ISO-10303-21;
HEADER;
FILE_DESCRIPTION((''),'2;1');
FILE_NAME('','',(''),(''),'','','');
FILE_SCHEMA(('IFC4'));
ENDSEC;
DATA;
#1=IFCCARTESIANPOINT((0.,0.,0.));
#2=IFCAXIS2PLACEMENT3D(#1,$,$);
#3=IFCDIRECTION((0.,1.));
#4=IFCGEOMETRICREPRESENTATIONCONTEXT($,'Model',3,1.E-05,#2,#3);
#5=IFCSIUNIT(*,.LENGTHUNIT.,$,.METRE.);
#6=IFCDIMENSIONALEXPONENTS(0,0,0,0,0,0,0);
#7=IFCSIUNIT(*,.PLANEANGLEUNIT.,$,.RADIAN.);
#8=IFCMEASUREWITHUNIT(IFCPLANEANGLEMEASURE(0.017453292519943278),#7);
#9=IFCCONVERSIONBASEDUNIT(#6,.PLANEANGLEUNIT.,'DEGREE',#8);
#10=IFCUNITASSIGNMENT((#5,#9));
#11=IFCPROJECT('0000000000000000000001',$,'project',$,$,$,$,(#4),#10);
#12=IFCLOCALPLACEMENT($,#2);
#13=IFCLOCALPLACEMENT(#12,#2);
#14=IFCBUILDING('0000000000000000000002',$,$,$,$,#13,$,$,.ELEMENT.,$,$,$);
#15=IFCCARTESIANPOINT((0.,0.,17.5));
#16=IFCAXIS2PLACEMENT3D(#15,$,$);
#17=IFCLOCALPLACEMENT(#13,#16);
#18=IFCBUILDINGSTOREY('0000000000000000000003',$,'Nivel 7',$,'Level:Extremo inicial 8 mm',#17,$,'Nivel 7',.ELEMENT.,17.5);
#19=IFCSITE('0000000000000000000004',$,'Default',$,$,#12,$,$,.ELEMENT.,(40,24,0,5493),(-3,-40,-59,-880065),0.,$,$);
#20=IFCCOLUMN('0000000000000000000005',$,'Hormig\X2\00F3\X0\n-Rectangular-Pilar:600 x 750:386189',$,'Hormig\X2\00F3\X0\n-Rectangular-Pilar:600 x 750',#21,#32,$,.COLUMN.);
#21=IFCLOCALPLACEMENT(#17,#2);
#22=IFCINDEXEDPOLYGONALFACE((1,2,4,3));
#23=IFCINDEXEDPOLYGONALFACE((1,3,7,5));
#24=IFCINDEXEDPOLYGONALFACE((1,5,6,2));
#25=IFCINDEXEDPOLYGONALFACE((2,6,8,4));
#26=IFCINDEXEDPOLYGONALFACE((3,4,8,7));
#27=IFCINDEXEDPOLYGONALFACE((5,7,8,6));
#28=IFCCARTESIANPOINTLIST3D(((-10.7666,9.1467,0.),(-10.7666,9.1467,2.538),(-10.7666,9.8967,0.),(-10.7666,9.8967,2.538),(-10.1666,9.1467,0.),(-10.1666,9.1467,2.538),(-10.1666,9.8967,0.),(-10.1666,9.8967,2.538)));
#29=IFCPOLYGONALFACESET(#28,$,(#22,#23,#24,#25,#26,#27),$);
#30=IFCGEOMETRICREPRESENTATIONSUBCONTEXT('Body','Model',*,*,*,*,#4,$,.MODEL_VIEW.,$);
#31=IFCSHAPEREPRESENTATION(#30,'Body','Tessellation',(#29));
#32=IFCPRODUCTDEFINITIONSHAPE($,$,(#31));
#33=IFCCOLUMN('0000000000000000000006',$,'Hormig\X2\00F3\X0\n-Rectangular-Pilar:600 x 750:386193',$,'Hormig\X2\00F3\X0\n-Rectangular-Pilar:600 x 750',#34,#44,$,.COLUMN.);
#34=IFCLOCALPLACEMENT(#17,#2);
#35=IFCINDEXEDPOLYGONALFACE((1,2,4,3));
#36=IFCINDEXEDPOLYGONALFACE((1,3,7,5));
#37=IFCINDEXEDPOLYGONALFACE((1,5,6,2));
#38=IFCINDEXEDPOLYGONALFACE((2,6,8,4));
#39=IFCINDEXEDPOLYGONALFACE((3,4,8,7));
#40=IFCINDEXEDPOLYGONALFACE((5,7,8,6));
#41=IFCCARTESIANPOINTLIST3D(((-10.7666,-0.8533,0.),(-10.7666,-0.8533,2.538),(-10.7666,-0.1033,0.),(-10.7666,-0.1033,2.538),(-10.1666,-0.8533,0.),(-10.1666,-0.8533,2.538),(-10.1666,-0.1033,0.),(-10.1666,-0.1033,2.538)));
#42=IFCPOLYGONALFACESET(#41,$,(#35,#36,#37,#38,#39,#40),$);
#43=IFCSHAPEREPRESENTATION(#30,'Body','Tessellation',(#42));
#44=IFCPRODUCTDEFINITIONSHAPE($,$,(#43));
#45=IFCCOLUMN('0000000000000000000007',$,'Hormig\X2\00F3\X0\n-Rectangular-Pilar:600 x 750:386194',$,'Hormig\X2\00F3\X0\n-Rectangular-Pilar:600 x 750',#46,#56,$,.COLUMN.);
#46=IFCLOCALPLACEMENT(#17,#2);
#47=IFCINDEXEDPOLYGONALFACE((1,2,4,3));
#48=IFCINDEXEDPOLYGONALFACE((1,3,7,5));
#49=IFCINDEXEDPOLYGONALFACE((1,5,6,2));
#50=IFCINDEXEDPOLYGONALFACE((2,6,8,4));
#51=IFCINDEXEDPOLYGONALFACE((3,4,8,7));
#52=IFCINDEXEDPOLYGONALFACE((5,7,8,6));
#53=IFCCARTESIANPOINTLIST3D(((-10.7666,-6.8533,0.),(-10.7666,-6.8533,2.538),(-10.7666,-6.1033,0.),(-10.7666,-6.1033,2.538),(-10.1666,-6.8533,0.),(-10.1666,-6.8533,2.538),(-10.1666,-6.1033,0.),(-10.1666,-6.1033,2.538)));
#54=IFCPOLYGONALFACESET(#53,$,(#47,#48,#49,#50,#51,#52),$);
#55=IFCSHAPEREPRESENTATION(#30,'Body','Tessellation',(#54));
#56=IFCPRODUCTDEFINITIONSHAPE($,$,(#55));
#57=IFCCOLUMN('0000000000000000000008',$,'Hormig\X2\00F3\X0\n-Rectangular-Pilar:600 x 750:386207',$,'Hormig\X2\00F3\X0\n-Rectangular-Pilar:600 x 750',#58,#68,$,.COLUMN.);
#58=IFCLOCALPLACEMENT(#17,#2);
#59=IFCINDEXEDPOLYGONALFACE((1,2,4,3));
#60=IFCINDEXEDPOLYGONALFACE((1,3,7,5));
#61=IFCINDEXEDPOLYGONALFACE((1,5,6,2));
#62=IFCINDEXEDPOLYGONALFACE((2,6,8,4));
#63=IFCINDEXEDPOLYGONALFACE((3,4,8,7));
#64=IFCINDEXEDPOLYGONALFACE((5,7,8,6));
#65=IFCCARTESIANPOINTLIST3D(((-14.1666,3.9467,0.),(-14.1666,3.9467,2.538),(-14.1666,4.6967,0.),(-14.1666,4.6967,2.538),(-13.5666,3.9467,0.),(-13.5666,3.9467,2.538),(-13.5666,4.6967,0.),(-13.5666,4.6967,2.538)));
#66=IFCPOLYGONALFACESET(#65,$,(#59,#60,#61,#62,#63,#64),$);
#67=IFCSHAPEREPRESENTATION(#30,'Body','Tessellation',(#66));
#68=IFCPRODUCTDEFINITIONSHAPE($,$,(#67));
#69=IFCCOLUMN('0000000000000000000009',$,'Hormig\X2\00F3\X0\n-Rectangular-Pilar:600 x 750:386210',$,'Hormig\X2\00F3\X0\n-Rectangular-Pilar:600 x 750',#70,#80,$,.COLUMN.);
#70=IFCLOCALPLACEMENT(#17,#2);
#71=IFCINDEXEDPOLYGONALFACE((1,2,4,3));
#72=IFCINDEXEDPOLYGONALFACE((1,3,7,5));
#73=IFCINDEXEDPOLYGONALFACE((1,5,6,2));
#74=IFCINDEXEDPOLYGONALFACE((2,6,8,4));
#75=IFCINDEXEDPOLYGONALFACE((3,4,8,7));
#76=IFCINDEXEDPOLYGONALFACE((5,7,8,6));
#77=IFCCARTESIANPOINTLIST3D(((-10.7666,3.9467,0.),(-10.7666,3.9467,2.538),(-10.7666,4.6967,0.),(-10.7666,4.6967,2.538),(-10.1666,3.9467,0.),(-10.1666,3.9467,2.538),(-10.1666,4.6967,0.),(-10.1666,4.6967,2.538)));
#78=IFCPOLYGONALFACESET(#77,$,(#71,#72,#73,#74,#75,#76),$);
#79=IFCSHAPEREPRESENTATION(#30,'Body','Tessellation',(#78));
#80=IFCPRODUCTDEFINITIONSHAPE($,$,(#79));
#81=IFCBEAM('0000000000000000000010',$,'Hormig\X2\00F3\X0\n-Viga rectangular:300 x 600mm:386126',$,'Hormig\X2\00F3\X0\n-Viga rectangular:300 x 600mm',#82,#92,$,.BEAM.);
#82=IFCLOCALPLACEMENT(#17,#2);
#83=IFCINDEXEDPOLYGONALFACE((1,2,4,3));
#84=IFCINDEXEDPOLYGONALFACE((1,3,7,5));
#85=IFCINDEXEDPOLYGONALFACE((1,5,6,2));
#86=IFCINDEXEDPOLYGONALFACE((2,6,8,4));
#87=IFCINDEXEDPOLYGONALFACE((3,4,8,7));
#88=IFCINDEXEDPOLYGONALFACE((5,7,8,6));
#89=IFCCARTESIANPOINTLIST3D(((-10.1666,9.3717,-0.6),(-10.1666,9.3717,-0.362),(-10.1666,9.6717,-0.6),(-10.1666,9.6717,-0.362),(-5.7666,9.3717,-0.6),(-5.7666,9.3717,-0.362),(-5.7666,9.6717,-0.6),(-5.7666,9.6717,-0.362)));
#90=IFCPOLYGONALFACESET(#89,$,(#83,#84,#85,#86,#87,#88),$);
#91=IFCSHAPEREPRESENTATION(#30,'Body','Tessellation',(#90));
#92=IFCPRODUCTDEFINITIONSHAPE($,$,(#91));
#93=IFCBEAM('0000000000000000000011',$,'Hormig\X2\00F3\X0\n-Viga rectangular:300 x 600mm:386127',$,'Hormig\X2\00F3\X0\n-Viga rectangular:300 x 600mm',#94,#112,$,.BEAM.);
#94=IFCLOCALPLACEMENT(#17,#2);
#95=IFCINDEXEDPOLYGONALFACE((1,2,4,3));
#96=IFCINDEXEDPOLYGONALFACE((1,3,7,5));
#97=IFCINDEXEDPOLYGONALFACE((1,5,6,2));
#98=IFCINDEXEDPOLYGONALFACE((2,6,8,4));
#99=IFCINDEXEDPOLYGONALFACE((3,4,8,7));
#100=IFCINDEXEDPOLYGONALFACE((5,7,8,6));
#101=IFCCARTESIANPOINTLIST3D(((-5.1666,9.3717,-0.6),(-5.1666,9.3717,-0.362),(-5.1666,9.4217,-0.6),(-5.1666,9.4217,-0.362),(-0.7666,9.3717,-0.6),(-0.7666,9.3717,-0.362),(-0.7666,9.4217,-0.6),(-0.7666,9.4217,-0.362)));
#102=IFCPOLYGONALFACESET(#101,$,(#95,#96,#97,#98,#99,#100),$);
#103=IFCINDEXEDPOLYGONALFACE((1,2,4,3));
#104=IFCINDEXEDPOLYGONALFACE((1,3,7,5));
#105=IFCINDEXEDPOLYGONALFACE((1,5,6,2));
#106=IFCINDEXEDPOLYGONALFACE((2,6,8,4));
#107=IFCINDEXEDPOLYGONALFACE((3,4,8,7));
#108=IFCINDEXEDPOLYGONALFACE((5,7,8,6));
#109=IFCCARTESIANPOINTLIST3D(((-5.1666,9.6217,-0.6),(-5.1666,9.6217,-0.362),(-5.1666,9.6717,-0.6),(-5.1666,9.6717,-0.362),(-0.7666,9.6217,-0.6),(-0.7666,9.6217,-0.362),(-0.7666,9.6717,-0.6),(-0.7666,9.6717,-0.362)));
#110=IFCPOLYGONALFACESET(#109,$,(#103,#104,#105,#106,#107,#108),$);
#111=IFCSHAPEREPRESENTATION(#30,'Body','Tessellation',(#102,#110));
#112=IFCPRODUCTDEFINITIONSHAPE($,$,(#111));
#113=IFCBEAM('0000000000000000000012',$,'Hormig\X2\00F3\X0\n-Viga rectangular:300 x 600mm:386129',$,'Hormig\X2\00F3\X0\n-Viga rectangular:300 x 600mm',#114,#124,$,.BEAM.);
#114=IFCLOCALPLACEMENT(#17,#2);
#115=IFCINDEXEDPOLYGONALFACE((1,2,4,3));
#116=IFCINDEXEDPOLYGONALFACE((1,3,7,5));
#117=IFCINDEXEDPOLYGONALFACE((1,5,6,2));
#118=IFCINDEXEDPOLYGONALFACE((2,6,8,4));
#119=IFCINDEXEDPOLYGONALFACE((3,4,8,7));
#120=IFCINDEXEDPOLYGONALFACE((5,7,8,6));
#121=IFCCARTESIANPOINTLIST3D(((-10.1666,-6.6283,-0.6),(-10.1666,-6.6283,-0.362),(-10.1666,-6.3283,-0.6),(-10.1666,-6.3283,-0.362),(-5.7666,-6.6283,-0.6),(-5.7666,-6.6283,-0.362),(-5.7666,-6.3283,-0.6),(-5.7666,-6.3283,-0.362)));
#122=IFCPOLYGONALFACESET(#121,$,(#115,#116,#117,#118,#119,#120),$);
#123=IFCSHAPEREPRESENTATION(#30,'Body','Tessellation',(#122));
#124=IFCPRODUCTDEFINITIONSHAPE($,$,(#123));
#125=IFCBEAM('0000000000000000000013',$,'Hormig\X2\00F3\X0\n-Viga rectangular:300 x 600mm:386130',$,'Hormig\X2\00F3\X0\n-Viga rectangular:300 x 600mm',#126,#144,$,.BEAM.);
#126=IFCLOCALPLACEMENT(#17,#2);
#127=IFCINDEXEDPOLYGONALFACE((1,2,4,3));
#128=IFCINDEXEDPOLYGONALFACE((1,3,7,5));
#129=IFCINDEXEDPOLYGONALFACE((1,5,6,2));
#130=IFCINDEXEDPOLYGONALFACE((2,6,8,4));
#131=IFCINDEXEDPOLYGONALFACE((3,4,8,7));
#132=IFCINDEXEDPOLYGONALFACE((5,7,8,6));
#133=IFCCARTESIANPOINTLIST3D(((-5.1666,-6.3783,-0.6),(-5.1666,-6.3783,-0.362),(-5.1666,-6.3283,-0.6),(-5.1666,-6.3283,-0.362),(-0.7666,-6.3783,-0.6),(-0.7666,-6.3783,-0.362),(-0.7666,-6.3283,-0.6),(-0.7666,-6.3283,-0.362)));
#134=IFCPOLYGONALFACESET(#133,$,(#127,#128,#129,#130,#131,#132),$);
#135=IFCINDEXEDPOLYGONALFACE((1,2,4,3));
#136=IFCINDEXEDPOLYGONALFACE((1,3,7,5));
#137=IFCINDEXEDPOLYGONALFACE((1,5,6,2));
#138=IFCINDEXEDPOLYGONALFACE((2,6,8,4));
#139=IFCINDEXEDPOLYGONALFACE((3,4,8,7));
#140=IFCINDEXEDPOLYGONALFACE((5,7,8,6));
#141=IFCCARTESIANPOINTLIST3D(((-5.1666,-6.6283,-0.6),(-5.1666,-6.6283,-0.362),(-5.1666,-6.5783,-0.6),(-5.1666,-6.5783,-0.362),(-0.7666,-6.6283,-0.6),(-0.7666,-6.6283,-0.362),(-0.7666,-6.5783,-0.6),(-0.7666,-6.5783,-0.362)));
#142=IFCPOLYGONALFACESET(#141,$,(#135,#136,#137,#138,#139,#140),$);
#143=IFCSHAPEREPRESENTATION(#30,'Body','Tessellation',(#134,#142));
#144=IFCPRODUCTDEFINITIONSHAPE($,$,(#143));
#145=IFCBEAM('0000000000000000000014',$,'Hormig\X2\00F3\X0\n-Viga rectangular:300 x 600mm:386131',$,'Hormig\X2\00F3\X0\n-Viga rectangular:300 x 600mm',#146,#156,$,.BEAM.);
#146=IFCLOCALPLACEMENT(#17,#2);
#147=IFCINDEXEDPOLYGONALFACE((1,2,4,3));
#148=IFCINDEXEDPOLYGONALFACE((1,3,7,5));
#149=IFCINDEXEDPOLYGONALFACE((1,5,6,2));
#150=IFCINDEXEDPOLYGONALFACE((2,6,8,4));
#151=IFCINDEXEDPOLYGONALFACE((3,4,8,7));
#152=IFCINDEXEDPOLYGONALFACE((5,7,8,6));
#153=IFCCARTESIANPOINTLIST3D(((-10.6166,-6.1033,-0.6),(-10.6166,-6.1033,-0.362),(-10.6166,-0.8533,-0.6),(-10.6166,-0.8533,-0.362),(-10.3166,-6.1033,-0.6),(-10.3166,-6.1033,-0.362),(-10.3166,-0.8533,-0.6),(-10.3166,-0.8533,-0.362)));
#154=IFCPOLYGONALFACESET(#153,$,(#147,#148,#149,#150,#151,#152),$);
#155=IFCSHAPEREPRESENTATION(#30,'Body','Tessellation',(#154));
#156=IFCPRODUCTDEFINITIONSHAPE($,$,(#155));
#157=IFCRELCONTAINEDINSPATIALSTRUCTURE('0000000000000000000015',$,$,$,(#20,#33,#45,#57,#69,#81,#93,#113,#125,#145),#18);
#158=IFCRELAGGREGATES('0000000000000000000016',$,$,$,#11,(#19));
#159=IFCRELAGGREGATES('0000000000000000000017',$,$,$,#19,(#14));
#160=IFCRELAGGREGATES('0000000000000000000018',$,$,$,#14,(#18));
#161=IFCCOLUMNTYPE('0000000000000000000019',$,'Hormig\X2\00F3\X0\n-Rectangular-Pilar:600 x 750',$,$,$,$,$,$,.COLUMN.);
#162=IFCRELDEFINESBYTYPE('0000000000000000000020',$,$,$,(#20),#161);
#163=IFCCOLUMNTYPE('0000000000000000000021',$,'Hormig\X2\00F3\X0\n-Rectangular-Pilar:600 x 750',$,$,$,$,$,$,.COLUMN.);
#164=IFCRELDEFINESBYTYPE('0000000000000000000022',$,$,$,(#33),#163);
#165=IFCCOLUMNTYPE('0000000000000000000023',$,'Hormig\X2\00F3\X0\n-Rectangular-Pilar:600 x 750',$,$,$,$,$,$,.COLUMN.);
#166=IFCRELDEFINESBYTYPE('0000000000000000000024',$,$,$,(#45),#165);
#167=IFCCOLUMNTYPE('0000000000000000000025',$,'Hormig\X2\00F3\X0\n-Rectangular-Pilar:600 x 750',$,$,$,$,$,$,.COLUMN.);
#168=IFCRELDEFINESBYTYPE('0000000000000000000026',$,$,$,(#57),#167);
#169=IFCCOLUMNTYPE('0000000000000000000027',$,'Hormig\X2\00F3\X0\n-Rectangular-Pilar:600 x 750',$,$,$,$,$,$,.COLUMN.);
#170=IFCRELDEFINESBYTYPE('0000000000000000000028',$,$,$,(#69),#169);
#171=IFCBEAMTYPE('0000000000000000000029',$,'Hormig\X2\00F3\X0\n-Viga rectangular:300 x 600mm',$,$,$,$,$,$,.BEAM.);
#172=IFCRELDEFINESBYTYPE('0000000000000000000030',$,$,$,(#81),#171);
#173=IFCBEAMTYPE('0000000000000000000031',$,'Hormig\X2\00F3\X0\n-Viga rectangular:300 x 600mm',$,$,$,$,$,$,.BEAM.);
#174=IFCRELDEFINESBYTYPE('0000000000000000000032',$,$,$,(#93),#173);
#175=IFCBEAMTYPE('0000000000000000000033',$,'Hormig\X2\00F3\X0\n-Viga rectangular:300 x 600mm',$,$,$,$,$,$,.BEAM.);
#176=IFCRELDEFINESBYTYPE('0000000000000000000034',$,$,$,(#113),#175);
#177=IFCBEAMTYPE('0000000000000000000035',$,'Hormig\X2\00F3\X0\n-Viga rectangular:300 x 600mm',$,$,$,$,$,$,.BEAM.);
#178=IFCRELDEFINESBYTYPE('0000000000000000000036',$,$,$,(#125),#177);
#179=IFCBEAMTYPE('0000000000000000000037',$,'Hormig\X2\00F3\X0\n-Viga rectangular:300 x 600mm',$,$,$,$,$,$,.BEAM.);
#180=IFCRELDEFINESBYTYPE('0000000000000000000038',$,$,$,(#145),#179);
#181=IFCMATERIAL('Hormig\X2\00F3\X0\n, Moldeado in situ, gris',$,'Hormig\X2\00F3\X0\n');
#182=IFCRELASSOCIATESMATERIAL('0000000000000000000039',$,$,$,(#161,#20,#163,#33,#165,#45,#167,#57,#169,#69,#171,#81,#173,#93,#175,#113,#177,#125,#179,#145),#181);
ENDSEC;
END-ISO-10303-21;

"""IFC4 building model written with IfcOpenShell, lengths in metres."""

from ifc_helpers import new_model, entity, si_unit, converted_unit, direction, frame, origin, place, context, subcontext, project, spatial, indexed_curve, outline, extrude, source, transform, mapped, material, type_object, type_shapes, element, save


model = new_model("IFC4")

# Units and contexts
model_context = context("Model", 3, precision=1e-05, world=origin(), true_north=direction((0.0, 1.0)))
body_context = subcontext(model_context, "Body", "Model", "MODEL_VIEW")
ifc_project = project(units=[si_unit("LENGTHUNIT", "METRE"), converted_unit("PLANEANGLEUNIT", "DEGREE", entity("IfcPlaneAngleMeasure", 0.017453292519943278), si_unit("PLANEANGLEUNIT", "RADIAN"), dimensions=[0, 0, 0, 0, 0, 0, 0])], contexts=[model_context])

# Site, building, storey
site_placement = place(None, origin())
site = spatial("IfcSite", under=ifc_project, at=site_placement, Name="Default", CompositionType="ELEMENT", RefLatitude=(40, 24, 0, 5493), RefLongitude=(-3, -40, -59, -880065), RefElevation=0.0)
building_placement = place(site_placement, origin())
building = spatial("IfcBuilding", under=site, at=building_placement, CompositionType="ELEMENT")
storey_placement = place(building_placement, frame((0.0, 0.0, 17.5)))
storey = spatial("IfcBuildingStorey", under=building, at=storey_placement, Name="Nivel 7", ObjectType="Level:Extremo inicial 8 mm", LongName="Nivel 7", CompositionType="ELEMENT", Elevation=17.5)

# Columns
ifc_material_1 = material(Name="Hormigón, Moldeado in situ, gris", Category="Hormigón")
column_type_1 = type_object("IfcColumnType", Name="Hormigón-Rectangular-Pilar:600 x 750", PredefinedType="COLUMN", material=ifc_material_1)
shared_shape_1 = source(origin(), body_context, "Body", "SweptSolid", [
    extrude(outline(indexed_curve([(-0.3, -0.375), (0.3, -0.375), (0.3, 0.375), (-0.3, 0.375), (-0.3, -0.375)], self_intersect=False)), frame((-10.4666, 9.5217, 17.5), z_axis=(0.0, 0.0, 1.0), x_axis=(-1.0, 0.0, 0.0)), (0.0, 0.0, 1.0), 2.538),
])
type_shapes(column_type_1, [shared_shape_1])
column_1_placement = place(storey_placement, frame((0.0, 0.0, -17.5)))
element("IfcColumn", 1, at=column_1_placement, inside=storey, type_object=column_type_1, material=ifc_material_1, Name="Hormigón-Rectangular-Pilar:600 x 750:386189", ObjectType="Hormigón-Rectangular-Pilar:600 x 750", PredefinedType="COLUMN", context=body_context, shape_type="MappedRepresentation", body=[
    mapped(shared_shape_1, transform((0.0, 0.0, 0.0), scale=1.0)),
])
column_type_2 = type_object("IfcColumnType", Name="Hormigón-Rectangular-Pilar:600 x 750", PredefinedType="COLUMN", material=ifc_material_1)
shared_shape_2 = source(origin(), body_context, "Body", "SweptSolid", [
    extrude(outline(indexed_curve([(-0.3, -0.375), (0.3, -0.375), (0.3, 0.375), (-0.3, 0.375), (-0.3, -0.375)], self_intersect=False)), frame((-10.4666, -0.4783, 17.5), z_axis=(0.0, 0.0, 1.0), x_axis=(-1.0, 0.0, 0.0)), (0.0, 0.0, 1.0), 2.538),
])
type_shapes(column_type_2, [shared_shape_2])
column_2_placement = place(storey_placement, frame((0.0, 0.0, -17.5)))
element("IfcColumn", 2, at=column_2_placement, inside=storey, type_object=column_type_2, material=ifc_material_1, Name="Hormigón-Rectangular-Pilar:600 x 750:386193", ObjectType="Hormigón-Rectangular-Pilar:600 x 750", PredefinedType="COLUMN", context=body_context, shape_type="MappedRepresentation", body=[
    mapped(shared_shape_2, transform((0.0, 0.0, 0.0), scale=1.0)),
])
column_type_3 = type_object("IfcColumnType", Name="Hormigón-Rectangular-Pilar:600 x 750", PredefinedType="COLUMN", material=ifc_material_1)
shared_shape_3 = source(origin(), body_context, "Body", "SweptSolid", [
    extrude(outline(indexed_curve([(-0.3, -0.375), (0.3, -0.375), (0.3, 0.375), (-0.3, 0.375), (-0.3, -0.375)], self_intersect=False)), frame((-10.4666, -6.4783, 17.5), z_axis=(0.0, 0.0, 1.0), x_axis=(-1.0, 0.0, 0.0)), (0.0, 0.0, 1.0), 2.538),
])
type_shapes(column_type_3, [shared_shape_3])
column_3_placement = place(storey_placement, frame((0.0, 0.0, -17.5)))
element("IfcColumn", 3, at=column_3_placement, inside=storey, type_object=column_type_3, material=ifc_material_1, Name="Hormigón-Rectangular-Pilar:600 x 750:386194", ObjectType="Hormigón-Rectangular-Pilar:600 x 750", PredefinedType="COLUMN", context=body_context, shape_type="MappedRepresentation", body=[
    mapped(shared_shape_3, transform((0.0, 0.0, 0.0), scale=1.0)),
])
column_type_4 = type_object("IfcColumnType", Name="Hormigón-Rectangular-Pilar:600 x 750", PredefinedType="COLUMN", material=ifc_material_1)
shared_shape_4 = source(origin(), body_context, "Body", "SweptSolid", [
    extrude(outline(indexed_curve([(-0.3, -0.375), (0.3, -0.375), (0.3, 0.375), (-0.3, 0.375), (-0.3, -0.375)], self_intersect=False)), frame((-13.8666, 4.3217, 17.5), z_axis=(0.0, 0.0, 1.0), x_axis=(-1.0, 0.0, 0.0)), (0.0, 0.0, 1.0), 2.538),
])
type_shapes(column_type_4, [shared_shape_4])
column_4_placement = place(storey_placement, frame((0.0, 0.0, -17.5)))
element("IfcColumn", 4, at=column_4_placement, inside=storey, type_object=column_type_4, material=ifc_material_1, Name="Hormigón-Rectangular-Pilar:600 x 750:386207", ObjectType="Hormigón-Rectangular-Pilar:600 x 750", PredefinedType="COLUMN", context=body_context, shape_type="MappedRepresentation", body=[
    mapped(shared_shape_4, transform((0.0, 0.0, 0.0), scale=1.0)),
])
column_type_5 = type_object("IfcColumnType", Name="Hormigón-Rectangular-Pilar:600 x 750", PredefinedType="COLUMN", material=ifc_material_1)
shared_shape_5 = source(origin(), body_context, "Body", "SweptSolid", [
    extrude(outline(indexed_curve([(-0.3, -0.375), (0.3, -0.375), (0.3, 0.375), (-0.3, 0.375), (-0.3, -0.375)], self_intersect=False)), frame((-10.4666, 4.3217, 17.5), z_axis=(0.0, 0.0, 1.0), x_axis=(-1.0, 0.0, 0.0)), (0.0, 0.0, 1.0), 2.538),
])
type_shapes(column_type_5, [shared_shape_5])
column_5_placement = place(storey_placement, frame((0.0, 0.0, -17.5)))
element("IfcColumn", 5, at=column_5_placement, inside=storey, type_object=column_type_5, material=ifc_material_1, Name="Hormigón-Rectangular-Pilar:600 x 750:386210", ObjectType="Hormigón-Rectangular-Pilar:600 x 750", PredefinedType="COLUMN", context=body_context, shape_type="MappedRepresentation", body=[
    mapped(shared_shape_5, transform((0.0, 0.0, 0.0), scale=1.0)),
])

# Beams
beam_type_1 = type_object("IfcBeamType", Name="Hormigón-Viga rectangular:300 x 600mm", PredefinedType="BEAM", material=ifc_material_1)
shared_shape_6 = source(origin(), body_context, "Body", "SweptSolid", [
    extrude(outline(indexed_curve([(-0.119, -0.15), (0.119, -0.15), (0.119, 0.15), (-0.119, 0.15), (-0.119, -0.15)], self_intersect=False)), frame((-5.7666, 9.5217, 17.019), z_axis=(-1.0, 0.0, 0.0), x_axis=(0.0, 0.0, -1.0)), (0.0, 0.0, 1.0), 4.4),
])
type_shapes(beam_type_1, [shared_shape_6])
beam_1_placement = place(storey_placement, frame((0.0, 0.0, -17.5)))
element("IfcBeam", 6, at=beam_1_placement, inside=storey, type_object=beam_type_1, material=ifc_material_1, Name="Hormigón-Viga rectangular:300 x 600mm:386126", ObjectType="Hormigón-Viga rectangular:300 x 600mm", PredefinedType="BEAM", context=body_context, shape_type="MappedRepresentation", body=[
    mapped(shared_shape_6, transform((0.0, 0.0, 0.0), scale=1.0)),
])
beam_type_2 = type_object("IfcBeamType", Name="Hormigón-Viga rectangular:300 x 600mm", PredefinedType="BEAM", material=ifc_material_1)
shared_shape_7 = source(origin(), body_context, "Body", "SweptSolid", [
    extrude(outline(indexed_curve([(-0.119, -0.025), (0.119, -0.025), (0.119, 0.025), (-0.119, 0.025), (-0.119, -0.025)], self_intersect=False)), frame((-5.1666, 9.3967, 17.019), z_axis=(1.0, 0.0, 0.0), x_axis=(0.0, 0.0, -1.0)), (0.0, 0.0, 1.0), 4.4),
    extrude(outline(indexed_curve([(-0.119, -0.025), (0.119, -0.025), (0.119, 0.025), (-0.119, 0.025), (-0.119, -0.025)], self_intersect=False)), frame((-5.1666, 9.6467, 17.019), z_axis=(1.0, 0.0, 0.0), x_axis=(0.0, 0.0, -1.0)), (0.0, 0.0, 1.0), 4.4),
])
type_shapes(beam_type_2, [shared_shape_7])
beam_2_placement = place(storey_placement, frame((0.0, 0.0, -17.5)))
element("IfcBeam", 7, at=beam_2_placement, inside=storey, type_object=beam_type_2, material=ifc_material_1, Name="Hormigón-Viga rectangular:300 x 600mm:386127", ObjectType="Hormigón-Viga rectangular:300 x 600mm", PredefinedType="BEAM", context=body_context, shape_type="MappedRepresentation", body=[
    mapped(shared_shape_7, transform((0.0, 0.0, 0.0), scale=1.0)),
])
beam_type_3 = type_object("IfcBeamType", Name="Hormigón-Viga rectangular:300 x 600mm", PredefinedType="BEAM", material=ifc_material_1)
shared_shape_8 = source(origin(), body_context, "Body", "SweptSolid", [
    extrude(outline(indexed_curve([(-0.119, -0.15), (0.119, -0.15), (0.119, 0.15), (-0.119, 0.15), (-0.119, -0.15)], self_intersect=False)), frame((-10.1666, -6.4783, 17.019), z_axis=(1.0, 0.0, 0.0), x_axis=(0.0, 0.0, -1.0)), (0.0, 0.0, 1.0), 4.4),
])
type_shapes(beam_type_3, [shared_shape_8])
beam_3_placement = place(storey_placement, frame((0.0, 0.0, -17.5)))
element("IfcBeam", 8, at=beam_3_placement, inside=storey, type_object=beam_type_3, material=ifc_material_1, Name="Hormigón-Viga rectangular:300 x 600mm:386129", ObjectType="Hormigón-Viga rectangular:300 x 600mm", PredefinedType="BEAM", context=body_context, shape_type="MappedRepresentation", body=[
    mapped(shared_shape_8, transform((0.0, 0.0, 0.0), scale=1.0)),
])
beam_type_4 = type_object("IfcBeamType", Name="Hormigón-Viga rectangular:300 x 600mm", PredefinedType="BEAM", material=ifc_material_1)
shared_shape_9 = source(origin(), body_context, "Body", "SweptSolid", [
    extrude(outline(indexed_curve([(-0.119, -0.025), (0.119, -0.025), (0.119, 0.025), (-0.119, 0.025), (-0.119, -0.025)], self_intersect=False)), frame((-0.7666, -6.3533, 17.019), z_axis=(-1.0, 0.0, 0.0), x_axis=(0.0, 0.0, -1.0)), (0.0, 0.0, 1.0), 4.4),
    extrude(outline(indexed_curve([(-0.119, -0.025), (0.119, -0.025), (0.119, 0.025), (-0.119, 0.025), (-0.119, -0.025)], self_intersect=False)), frame((-0.7666, -6.6033, 17.019), z_axis=(-1.0, 0.0, 0.0), x_axis=(0.0, 0.0, -1.0)), (0.0, 0.0, 1.0), 4.4),
])
type_shapes(beam_type_4, [shared_shape_9])
beam_4_placement = place(storey_placement, frame((0.0, 0.0, -17.5)))
element("IfcBeam", 9, at=beam_4_placement, inside=storey, type_object=beam_type_4, material=ifc_material_1, Name="Hormigón-Viga rectangular:300 x 600mm:386130", ObjectType="Hormigón-Viga rectangular:300 x 600mm", PredefinedType="BEAM", context=body_context, shape_type="MappedRepresentation", body=[
    mapped(shared_shape_9, transform((0.0, 0.0, 0.0), scale=1.0)),
])
beam_type_5 = type_object("IfcBeamType", Name="Hormigón-Viga rectangular:300 x 600mm", PredefinedType="BEAM", material=ifc_material_1)
shared_shape_10 = source(origin(), body_context, "Body", "SweptSolid", [
    extrude(outline(indexed_curve([(-0.15, -0.119), (0.15, -0.119), (0.15, 0.119), (-0.15, 0.119), (-0.15, -0.119)], self_intersect=False)), frame((-10.4666, -6.1033, 17.019), z_axis=(0.0, 1.0, 0.0), x_axis=(-1.0, 0.0, 0.0)), (0.0, 0.0, 1.0), 5.25),
])
type_shapes(beam_type_5, [shared_shape_10])
beam_5_placement = place(storey_placement, frame((0.0, 0.0, -17.5)))
element("IfcBeam", 10, at=beam_5_placement, inside=storey, type_object=beam_type_5, material=ifc_material_1, Name="Hormigón-Viga rectangular:300 x 600mm:386131", ObjectType="Hormigón-Viga rectangular:300 x 600mm", PredefinedType="BEAM", context=body_context, shape_type="MappedRepresentation", body=[
    mapped(shared_shape_10, transform((0.0, 0.0, 0.0), scale=1.0)),
])

save(model, "model.ifc")
